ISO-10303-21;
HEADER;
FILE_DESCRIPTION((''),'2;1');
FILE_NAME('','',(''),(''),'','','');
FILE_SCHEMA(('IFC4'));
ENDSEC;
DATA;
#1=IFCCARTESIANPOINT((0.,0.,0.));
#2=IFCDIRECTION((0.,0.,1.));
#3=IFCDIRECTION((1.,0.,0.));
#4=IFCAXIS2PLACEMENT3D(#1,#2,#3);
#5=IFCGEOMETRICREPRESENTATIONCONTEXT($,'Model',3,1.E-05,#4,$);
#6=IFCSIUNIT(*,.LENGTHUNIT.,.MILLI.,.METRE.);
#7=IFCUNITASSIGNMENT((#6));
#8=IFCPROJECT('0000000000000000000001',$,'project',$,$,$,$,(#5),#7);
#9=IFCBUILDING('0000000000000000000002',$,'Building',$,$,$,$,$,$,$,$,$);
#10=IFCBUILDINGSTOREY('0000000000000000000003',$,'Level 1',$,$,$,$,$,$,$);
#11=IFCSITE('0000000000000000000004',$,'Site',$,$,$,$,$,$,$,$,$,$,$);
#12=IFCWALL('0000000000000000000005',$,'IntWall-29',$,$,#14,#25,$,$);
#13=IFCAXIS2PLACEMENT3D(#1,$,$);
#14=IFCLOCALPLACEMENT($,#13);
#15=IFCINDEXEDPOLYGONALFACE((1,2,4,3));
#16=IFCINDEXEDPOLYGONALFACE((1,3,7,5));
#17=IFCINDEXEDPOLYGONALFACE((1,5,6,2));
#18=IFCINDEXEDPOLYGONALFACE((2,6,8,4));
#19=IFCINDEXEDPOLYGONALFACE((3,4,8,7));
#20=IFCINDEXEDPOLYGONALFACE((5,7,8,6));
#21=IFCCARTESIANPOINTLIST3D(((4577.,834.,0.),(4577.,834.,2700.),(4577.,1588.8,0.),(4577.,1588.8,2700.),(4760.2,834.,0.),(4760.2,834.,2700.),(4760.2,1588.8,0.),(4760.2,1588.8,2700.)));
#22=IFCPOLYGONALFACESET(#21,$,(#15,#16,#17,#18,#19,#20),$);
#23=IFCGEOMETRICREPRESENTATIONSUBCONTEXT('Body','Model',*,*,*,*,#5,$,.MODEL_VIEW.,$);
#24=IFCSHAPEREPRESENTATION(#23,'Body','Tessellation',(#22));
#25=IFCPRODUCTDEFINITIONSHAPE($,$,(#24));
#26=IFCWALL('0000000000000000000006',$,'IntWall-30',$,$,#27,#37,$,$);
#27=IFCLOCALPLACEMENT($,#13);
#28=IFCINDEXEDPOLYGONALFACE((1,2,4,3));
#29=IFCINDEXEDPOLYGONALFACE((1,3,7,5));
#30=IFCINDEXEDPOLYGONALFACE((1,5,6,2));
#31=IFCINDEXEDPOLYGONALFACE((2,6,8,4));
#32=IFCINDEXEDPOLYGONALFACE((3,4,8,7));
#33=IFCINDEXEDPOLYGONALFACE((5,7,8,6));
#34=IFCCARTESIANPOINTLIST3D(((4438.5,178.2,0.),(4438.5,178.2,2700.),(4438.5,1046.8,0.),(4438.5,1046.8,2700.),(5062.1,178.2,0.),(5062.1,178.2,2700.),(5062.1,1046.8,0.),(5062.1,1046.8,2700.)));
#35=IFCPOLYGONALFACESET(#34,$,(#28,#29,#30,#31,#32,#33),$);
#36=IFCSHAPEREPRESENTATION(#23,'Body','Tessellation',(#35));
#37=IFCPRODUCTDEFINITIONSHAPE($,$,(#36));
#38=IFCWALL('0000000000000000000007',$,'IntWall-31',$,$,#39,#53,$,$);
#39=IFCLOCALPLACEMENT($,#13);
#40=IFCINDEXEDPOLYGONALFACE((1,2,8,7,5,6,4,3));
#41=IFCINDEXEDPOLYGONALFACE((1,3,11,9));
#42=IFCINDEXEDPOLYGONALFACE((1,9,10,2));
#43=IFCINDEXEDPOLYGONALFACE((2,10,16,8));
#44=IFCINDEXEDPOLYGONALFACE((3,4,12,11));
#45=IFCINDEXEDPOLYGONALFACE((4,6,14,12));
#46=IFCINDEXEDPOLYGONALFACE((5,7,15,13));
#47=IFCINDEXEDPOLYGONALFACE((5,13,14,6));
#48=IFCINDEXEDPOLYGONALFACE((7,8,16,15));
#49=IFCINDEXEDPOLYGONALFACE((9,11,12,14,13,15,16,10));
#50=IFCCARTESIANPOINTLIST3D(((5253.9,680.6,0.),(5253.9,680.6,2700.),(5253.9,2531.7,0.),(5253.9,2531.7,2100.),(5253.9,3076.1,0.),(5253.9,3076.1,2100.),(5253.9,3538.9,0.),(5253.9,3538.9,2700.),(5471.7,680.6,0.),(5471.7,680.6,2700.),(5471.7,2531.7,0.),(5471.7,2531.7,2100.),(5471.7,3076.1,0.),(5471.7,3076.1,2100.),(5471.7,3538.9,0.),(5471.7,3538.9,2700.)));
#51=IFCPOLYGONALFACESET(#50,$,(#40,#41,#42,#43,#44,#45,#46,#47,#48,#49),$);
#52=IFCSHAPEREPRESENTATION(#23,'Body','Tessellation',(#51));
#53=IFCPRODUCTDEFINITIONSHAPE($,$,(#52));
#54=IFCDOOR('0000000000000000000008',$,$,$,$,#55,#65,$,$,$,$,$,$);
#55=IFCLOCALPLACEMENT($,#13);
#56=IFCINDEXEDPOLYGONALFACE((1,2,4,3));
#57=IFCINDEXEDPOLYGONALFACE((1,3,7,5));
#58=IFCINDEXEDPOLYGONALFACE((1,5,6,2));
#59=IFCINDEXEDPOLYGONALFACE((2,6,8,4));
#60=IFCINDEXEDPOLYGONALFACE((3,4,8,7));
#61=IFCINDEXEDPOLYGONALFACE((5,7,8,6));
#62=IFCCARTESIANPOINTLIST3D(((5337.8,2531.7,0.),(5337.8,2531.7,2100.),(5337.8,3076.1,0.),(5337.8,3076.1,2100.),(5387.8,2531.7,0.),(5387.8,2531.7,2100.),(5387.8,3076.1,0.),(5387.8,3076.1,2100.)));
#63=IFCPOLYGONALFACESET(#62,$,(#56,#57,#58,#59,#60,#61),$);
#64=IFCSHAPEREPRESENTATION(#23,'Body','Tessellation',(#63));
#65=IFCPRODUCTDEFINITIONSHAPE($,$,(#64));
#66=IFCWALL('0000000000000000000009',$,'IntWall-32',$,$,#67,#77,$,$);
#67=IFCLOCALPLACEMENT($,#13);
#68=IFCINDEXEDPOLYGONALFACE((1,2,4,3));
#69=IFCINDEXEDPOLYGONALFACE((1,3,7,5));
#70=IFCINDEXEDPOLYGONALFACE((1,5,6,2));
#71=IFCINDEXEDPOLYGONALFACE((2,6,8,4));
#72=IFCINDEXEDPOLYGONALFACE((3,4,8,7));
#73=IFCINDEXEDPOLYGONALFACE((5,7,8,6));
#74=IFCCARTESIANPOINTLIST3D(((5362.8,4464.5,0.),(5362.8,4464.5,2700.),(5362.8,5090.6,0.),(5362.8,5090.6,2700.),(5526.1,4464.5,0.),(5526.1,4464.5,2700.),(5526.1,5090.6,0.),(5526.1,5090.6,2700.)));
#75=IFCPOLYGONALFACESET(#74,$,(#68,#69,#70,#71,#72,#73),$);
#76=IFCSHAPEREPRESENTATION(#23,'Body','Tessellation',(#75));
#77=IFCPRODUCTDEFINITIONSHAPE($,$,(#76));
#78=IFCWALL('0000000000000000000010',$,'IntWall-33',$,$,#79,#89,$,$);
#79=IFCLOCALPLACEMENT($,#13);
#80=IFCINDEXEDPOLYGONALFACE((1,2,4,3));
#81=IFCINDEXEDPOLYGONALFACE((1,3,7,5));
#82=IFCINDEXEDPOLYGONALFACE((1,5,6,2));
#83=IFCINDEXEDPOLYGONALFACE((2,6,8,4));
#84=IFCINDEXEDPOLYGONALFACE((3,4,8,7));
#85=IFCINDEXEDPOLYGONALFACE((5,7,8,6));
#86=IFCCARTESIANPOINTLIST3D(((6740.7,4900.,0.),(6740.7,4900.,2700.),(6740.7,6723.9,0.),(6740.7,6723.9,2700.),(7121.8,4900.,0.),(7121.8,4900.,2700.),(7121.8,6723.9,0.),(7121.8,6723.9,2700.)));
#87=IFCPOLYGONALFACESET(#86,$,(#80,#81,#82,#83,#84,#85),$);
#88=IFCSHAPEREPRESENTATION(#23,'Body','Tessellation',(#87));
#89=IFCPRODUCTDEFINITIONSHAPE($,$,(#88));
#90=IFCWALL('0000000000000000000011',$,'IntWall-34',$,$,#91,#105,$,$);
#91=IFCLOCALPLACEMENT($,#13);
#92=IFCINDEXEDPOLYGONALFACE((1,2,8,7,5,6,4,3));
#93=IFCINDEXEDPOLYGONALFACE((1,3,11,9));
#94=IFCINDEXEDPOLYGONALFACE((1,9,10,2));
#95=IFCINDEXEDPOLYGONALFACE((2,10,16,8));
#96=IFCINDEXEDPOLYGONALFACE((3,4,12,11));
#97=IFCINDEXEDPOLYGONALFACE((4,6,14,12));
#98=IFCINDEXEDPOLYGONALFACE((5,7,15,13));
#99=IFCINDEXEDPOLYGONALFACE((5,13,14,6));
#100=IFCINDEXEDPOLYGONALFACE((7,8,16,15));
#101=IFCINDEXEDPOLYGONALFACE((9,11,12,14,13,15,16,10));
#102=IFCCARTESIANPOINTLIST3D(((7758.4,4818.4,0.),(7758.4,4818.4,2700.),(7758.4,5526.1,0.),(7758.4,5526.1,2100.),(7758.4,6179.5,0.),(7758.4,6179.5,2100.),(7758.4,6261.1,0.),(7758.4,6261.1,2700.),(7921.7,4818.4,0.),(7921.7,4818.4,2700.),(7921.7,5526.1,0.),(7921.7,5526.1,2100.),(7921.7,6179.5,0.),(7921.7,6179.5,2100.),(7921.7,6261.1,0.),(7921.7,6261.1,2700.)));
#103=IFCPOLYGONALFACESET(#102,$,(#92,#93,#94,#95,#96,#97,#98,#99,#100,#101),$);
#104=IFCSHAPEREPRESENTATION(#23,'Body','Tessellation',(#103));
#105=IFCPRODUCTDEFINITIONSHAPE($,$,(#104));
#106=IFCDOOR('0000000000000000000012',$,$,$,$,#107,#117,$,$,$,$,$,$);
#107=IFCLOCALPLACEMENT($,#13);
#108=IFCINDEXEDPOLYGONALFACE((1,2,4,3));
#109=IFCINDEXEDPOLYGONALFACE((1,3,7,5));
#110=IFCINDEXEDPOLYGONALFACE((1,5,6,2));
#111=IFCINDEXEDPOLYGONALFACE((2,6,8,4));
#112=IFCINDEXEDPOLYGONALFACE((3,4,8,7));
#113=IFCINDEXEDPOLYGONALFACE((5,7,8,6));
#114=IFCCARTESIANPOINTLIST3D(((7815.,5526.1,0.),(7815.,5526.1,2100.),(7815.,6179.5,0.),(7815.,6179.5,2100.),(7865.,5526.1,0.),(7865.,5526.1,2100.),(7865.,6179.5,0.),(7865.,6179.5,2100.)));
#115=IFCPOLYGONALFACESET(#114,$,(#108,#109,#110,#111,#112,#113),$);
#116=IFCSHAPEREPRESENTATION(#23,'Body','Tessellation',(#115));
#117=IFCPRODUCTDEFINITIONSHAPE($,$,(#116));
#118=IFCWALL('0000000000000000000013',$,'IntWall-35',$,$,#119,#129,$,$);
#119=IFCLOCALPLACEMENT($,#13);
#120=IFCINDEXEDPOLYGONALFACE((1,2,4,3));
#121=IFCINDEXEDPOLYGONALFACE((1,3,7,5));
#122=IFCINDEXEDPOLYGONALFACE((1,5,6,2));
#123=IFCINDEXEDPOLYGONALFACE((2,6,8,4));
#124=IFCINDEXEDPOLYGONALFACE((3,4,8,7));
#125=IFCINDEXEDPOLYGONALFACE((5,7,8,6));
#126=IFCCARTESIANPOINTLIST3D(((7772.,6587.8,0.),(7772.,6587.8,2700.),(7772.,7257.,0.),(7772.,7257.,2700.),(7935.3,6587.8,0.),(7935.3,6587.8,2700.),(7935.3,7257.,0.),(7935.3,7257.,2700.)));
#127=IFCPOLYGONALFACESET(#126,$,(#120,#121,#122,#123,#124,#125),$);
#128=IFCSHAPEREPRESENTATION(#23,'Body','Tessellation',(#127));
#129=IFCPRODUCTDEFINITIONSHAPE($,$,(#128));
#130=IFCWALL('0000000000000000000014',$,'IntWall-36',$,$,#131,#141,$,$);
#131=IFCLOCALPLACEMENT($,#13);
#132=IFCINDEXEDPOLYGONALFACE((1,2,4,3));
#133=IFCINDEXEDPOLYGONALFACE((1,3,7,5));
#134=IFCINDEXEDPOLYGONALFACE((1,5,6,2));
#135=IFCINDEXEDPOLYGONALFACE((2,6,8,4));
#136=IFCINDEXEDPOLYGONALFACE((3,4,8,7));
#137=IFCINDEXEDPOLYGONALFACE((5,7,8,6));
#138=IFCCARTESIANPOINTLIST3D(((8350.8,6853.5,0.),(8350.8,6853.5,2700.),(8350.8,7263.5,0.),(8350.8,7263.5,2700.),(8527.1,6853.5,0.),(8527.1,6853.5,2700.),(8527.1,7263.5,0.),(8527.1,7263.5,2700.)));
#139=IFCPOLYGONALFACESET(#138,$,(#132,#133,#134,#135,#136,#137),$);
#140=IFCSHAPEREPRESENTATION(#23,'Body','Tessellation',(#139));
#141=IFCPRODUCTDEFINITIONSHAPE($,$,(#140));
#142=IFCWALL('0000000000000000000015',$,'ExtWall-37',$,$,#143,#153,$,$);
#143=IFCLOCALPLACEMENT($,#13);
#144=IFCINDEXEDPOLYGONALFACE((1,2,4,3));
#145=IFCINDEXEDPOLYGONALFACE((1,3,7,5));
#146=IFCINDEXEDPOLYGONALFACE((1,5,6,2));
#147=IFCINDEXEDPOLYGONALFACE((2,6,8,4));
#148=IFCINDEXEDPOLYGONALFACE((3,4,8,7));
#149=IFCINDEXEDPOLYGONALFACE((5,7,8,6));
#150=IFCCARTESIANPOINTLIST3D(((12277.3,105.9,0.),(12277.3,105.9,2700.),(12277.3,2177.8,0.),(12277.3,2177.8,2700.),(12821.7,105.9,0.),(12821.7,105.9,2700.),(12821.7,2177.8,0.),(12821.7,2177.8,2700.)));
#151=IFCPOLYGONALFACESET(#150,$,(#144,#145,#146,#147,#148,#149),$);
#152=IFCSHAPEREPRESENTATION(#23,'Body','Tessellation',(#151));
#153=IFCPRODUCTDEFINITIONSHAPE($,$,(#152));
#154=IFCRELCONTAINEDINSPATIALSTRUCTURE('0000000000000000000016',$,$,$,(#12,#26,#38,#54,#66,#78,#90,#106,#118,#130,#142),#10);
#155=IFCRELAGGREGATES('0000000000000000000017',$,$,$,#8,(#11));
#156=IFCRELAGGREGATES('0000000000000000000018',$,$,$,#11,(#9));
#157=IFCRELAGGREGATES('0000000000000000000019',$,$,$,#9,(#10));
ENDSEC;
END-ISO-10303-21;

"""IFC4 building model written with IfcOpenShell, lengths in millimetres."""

from ifc_helpers import new_model, si_unit, frame, origin_with_axes, place, context, subcontext, project, spatial, indexed_curve, outline, extrude, element, fill, save


model = new_model("IFC4")

# Units and contexts
model_context = context("Model", 3, precision=1e-05, world=origin_with_axes())
body_context = subcontext(model_context, "Body", "Model", "MODEL_VIEW")
ifc_project = project(units=[si_unit("LENGTHUNIT", "METRE", prefix="MILLI")], contexts=[model_context])

# Site, building, storey
site = spatial("IfcSite", under=ifc_project, Name="Site")
building = spatial("IfcBuilding", under=site, Name="Building")
storey = spatial("IfcBuildingStorey", under=building, Name="Level 1")

# Walls
wall_1_placement = place(None, frame((4668.6, 834.0, 0.0), z_axis=(0.0, 0.0, 1.0), x_axis=(0.0, 1.0, 0.0)))
element("IfcWall", 1, at=wall_1_placement, inside=storey, Name="IntWall-29", context=body_context, shape_type="SweptSolid", body=[
    extrude(outline(indexed_curve([(0.0, 0.0), (0.0, 183.2), (754.9, 183.2), (754.9, 0.0), (0.0, 0.0)], self_intersect=False)), frame((0.0, -91.6, 0.0), z_axis=(0.0, 0.0, 1.0), x_axis=(1.0, 0.0, 0.0)), (0.0, 0.0, 1.0), 2700.0),
])
wall_2_placement = place(None, frame((4750.3, 178.2, 0.0), z_axis=(0.0, 0.0, 1.0), x_axis=(0.0, 1.0, 0.0)))
element("IfcWall", 2, at=wall_2_placement, inside=storey, Name="IntWall-30", context=body_context, shape_type="SweptSolid", body=[
    extrude(outline(indexed_curve([(0.0, 0.0), (0.0, 623.6), (868.6, 623.6), (868.6, 0.0), (0.0, 0.0)], self_intersect=False)), frame((0.0, -311.8, 0.0), z_axis=(0.0, 0.0, 1.0), x_axis=(1.0, 0.0, 0.0)), (0.0, 0.0, 1.0), 2700.0),
])

# Wall, opening, door
wall_3_placement = place(None, frame((5362.8, 680.6, 0.0), z_axis=(0.0, 0.0, 1.0), x_axis=(0.0, 1.0, 0.0)))
wall_3 = element("IfcWall", 3, at=wall_3_placement, inside=storey, Name="IntWall-31", context=body_context, shape_type="SweptSolid", body=[
    extrude(outline(indexed_curve([(0.0, 0.0), (0.0, 217.8), (2858.3, 217.8), (2858.3, 0.0), (0.0, 0.0)], self_intersect=False)), frame((0.0, -108.9, 0.0), z_axis=(0.0, 0.0, 1.0), x_axis=(1.0, 0.0, 0.0)), (0.0, 0.0, 1.0), 2700.0),
])
opening_1_placement = place(wall_3_placement, frame((1851.1, 0.0, 0.0), z_axis=(0.0, 0.0, 1.0), x_axis=(1.0, 0.0, 0.0)))
opening_1 = element("IfcOpeningElement", 4, at=opening_1_placement, cuts=wall_3, context=body_context, shape_type="SweptSolid", body=[
    extrude(outline(indexed_curve([(0.0, 0.0), (0.0, 317.8), (544.4, 317.8), (544.4, 0.0), (0.0, 0.0)], self_intersect=False)), frame((0.0, -158.9, 0.0), z_axis=(0.0, 0.0, 1.0), x_axis=(1.0, 0.0, 0.0)), (0.0, 0.0, 1.0), 2100.0),
])
door_1_placement = place(opening_1_placement, origin_with_axes())
door_1 = element("IfcDoor", 5, at=door_1_placement, inside=storey, context=body_context, shape_type="SweptSolid", body=[
    extrude(outline(indexed_curve([(0.0, 0.0), (0.0, 50.0), (544.4, 50.0), (544.4, 0.0), (0.0, 0.0)], self_intersect=False)), frame((0.0, -25.0, 0.0), z_axis=(0.0, 0.0, 1.0), x_axis=(1.0, 0.0, 0.0)), (0.0, 0.0, 1.0), 2100.0),
])
fill(opening_1, door_1)

# Walls
wall_4_placement = place(None, frame((5444.5, 4464.5, 0.0), z_axis=(0.0, 0.0, 1.0), x_axis=(0.0, 1.0, 0.0)))
element("IfcWall", 6, at=wall_4_placement, inside=storey, Name="IntWall-32", context=body_context, shape_type="SweptSolid", body=[
    extrude(outline(indexed_curve([(0.0, 0.0), (0.0, 163.3), (626.1, 163.3), (626.1, 0.0), (0.0, 0.0)], self_intersect=False)), frame((0.0, -81.7, 0.0), z_axis=(0.0, 0.0, 1.0), x_axis=(1.0, 0.0, 0.0)), (0.0, 0.0, 1.0), 2700.0),
])
wall_5_placement = place(None, frame((6931.2, 4900.0, 0.0), z_axis=(0.0, 0.0, 1.0), x_axis=(0.0, 1.0, 0.0)))
element("IfcWall", 7, at=wall_5_placement, inside=storey, Name="IntWall-33", context=body_context, shape_type="SweptSolid", body=[
    extrude(outline(indexed_curve([(0.0, 0.0), (0.0, 381.1), (1823.9, 381.1), (1823.9, 0.0), (0.0, 0.0)], self_intersect=False)), frame((0.0, -190.6, 0.0), z_axis=(0.0, 0.0, 1.0), x_axis=(1.0, 0.0, 0.0)), (0.0, 0.0, 1.0), 2700.0),
])

# Wall, opening, door
wall_6_placement = place(None, frame((7840.0, 4818.4, 0.0), z_axis=(0.0, 0.0, 1.0), x_axis=(0.0, 1.0, 0.0)))
wall_6 = element("IfcWall", 8, at=wall_6_placement, inside=storey, Name="IntWall-34", context=body_context, shape_type="SweptSolid", body=[
    extrude(outline(indexed_curve([(0.0, 0.0), (0.0, 163.3), (1442.8, 163.3), (1442.8, 0.0), (0.0, 0.0)], self_intersect=False)), frame((0.0, -81.7, 0.0), z_axis=(0.0, 0.0, 1.0), x_axis=(1.0, 0.0, 0.0)), (0.0, 0.0, 1.0), 2700.0),
])
opening_2_placement = place(wall_6_placement, frame((707.8, 0.0, 0.0), z_axis=(0.0, 0.0, 1.0), x_axis=(1.0, 0.0, 0.0)))
opening_2 = element("IfcOpeningElement", 9, at=opening_2_placement, cuts=wall_6, context=body_context, shape_type="SweptSolid", body=[
    extrude(outline(indexed_curve([(0.0, 0.0), (0.0, 263.3), (653.3, 263.3), (653.3, 0.0), (0.0, 0.0)], self_intersect=False)), frame((0.0, -131.7, 0.0), z_axis=(0.0, 0.0, 1.0), x_axis=(1.0, 0.0, 0.0)), (0.0, 0.0, 1.0), 2100.0),
])
door_2_placement = place(opening_2_placement, origin_with_axes())
door_2 = element("IfcDoor", 10, at=door_2_placement, inside=storey, context=body_context, shape_type="SweptSolid", body=[
    extrude(outline(indexed_curve([(0.0, 0.0), (0.0, 50.0), (653.3, 50.0), (653.3, 0.0), (0.0, 0.0)], self_intersect=False)), frame((0.0, -25.0, 0.0), z_axis=(0.0, 0.0, 1.0), x_axis=(1.0, 0.0, 0.0)), (0.0, 0.0, 1.0), 2100.0),
])
fill(opening_2, door_2)

# Walls
wall_7_placement = place(None, frame((7853.7, 6587.8, 0.0), z_axis=(0.0, 0.0, 1.0), x_axis=(0.0, 1.0, 0.0)))
element("IfcWall", 11, at=wall_7_placement, inside=storey, Name="IntWall-35", context=body_context, shape_type="SweptSolid", body=[
    extrude(outline(indexed_curve([(0.0, 0.0), (0.0, 163.3), (669.2, 163.3), (669.2, 0.0), (0.0, 0.0)], self_intersect=False)), frame((0.0, -81.7, 0.0), z_axis=(0.0, 0.0, 1.0), x_axis=(1.0, 0.0, 0.0)), (0.0, 0.0, 1.0), 2700.0),
])
wall_8_placement = place(None, frame((8438.9, 6853.5, 0.0), z_axis=(0.0, 0.0, 1.0), x_axis=(0.0, 1.0, 0.0)))
element("IfcWall", 12, at=wall_8_placement, inside=storey, Name="IntWall-36", context=body_context, shape_type="SweptSolid", body=[
    extrude(outline(indexed_curve([(0.0, 0.0), (0.0, 176.3), (409.9, 176.3), (409.9, 0.0), (0.0, 0.0)], self_intersect=False)), frame((0.0, -88.2, 0.0), z_axis=(0.0, 0.0, 1.0), x_axis=(1.0, 0.0, 0.0)), (0.0, 0.0, 1.0), 2700.0),
])
wall_9_placement = place(None, frame((12549.5, 105.9, 0.0), z_axis=(0.0, 0.0, 1.0), x_axis=(0.0, 1.0, 0.0)))
element("IfcWall", 13, at=wall_9_placement, inside=storey, Name="ExtWall-37", context=body_context, shape_type="SweptSolid", body=[
    extrude(outline(indexed_curve([(0.0, 0.0), (0.0, 544.4), (2071.9, 544.4), (2071.9, 0.0), (0.0, 0.0)], self_intersect=False)), frame((0.0, -272.2, 0.0), z_axis=(0.0, 0.0, 1.0), x_axis=(1.0, 0.0, 0.0)), (0.0, 0.0, 1.0), 2700.0),
])

save(model, "model.ifc")
